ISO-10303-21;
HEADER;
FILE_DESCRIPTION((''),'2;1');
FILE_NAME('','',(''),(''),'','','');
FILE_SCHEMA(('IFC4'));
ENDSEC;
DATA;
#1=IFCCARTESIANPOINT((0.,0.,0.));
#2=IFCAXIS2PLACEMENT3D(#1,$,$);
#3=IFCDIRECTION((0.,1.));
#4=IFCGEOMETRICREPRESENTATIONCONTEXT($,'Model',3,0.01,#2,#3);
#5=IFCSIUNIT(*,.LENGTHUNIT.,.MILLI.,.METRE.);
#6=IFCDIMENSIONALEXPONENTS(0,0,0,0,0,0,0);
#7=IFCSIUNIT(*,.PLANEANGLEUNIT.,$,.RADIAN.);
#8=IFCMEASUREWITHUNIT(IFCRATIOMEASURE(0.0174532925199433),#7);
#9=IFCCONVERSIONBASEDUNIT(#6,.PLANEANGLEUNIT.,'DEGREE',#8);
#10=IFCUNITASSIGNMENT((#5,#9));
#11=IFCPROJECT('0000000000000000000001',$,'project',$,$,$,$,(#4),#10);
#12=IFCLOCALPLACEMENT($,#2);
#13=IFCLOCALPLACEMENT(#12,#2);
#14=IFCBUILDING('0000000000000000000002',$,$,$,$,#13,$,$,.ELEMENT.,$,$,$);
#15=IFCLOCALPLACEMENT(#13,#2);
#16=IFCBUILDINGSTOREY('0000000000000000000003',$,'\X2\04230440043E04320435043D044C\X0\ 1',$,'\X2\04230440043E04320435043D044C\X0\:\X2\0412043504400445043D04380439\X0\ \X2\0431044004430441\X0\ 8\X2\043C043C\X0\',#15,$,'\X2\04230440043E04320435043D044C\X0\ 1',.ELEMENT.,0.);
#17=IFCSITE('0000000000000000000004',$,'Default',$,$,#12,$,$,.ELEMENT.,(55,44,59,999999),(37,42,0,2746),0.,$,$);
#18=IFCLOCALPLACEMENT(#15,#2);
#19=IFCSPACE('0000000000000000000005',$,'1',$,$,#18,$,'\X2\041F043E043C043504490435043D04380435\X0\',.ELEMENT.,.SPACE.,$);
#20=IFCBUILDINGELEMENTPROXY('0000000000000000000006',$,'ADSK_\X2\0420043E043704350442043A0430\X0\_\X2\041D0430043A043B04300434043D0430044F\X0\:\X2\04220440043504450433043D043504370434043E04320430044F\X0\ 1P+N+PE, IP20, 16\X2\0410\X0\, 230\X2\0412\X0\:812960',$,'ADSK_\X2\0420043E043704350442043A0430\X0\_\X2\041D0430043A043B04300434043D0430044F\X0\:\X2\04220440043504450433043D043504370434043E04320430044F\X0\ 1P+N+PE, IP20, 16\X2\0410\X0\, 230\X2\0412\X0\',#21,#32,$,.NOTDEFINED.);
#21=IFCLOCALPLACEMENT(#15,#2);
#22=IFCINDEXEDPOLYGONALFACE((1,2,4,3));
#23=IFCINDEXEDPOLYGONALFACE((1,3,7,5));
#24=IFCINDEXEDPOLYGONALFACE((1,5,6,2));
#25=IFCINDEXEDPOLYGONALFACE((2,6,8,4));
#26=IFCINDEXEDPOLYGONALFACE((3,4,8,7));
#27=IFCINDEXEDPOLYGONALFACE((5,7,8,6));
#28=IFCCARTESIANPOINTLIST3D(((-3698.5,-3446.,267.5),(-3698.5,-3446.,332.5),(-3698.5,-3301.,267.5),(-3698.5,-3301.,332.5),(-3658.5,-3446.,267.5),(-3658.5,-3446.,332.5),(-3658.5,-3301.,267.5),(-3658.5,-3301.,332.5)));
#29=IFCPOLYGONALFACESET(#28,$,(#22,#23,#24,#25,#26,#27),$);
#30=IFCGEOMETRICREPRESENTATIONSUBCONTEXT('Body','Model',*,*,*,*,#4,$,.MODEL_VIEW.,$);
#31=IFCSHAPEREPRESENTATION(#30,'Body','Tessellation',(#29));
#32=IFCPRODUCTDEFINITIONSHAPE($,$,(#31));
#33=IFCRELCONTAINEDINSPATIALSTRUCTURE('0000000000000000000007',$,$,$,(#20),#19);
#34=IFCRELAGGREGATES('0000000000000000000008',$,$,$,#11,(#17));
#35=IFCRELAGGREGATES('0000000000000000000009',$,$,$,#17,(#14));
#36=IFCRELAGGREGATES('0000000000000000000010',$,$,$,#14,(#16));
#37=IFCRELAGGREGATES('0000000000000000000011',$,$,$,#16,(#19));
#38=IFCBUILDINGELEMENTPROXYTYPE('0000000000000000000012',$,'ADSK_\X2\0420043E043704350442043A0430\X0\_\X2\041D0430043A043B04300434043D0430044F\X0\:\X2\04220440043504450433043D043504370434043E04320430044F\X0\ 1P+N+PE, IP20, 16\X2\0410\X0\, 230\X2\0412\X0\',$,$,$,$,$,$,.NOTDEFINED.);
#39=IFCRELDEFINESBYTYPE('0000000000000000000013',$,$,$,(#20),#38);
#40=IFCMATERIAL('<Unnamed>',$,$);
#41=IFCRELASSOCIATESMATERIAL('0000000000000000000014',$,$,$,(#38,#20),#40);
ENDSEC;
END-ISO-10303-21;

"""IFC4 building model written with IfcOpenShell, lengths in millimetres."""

from ifc_helpers import new_model, entity, si_unit, converted_unit, direction, frame, origin, origin_2d_with_axis, place, context, subcontext, project, spatial, rectangle, extrude, source, transform, mapped, material, type_object, type_shapes, element, save


model = new_model("IFC4")

# Units and contexts
model_context = context("Model", 3, precision=0.01, world=origin(), true_north=direction((0.0, 1.0)))
body_context = subcontext(model_context, "Body", "Model", "MODEL_VIEW")
ifc_project = project(units=[si_unit("LENGTHUNIT", "METRE", prefix="MILLI"), converted_unit("PLANEANGLEUNIT", "DEGREE", entity("IfcRatioMeasure", 0.0174532925199433), si_unit("PLANEANGLEUNIT", "RADIAN"), dimensions=[0, 0, 0, 0, 0, 0, 0])], contexts=[model_context])

# Site, building, storey
site_placement = place(None, origin())
site = spatial("IfcSite", under=ifc_project, at=site_placement, Name="Default", CompositionType="ELEMENT", RefLatitude=(55, 44, 59, 999999), RefLongitude=(37, 42, 0, 2746), RefElevation=0.0)
building_placement = place(site_placement, origin())
building = spatial("IfcBuilding", under=site, at=building_placement, CompositionType="ELEMENT")
storey_placement = place(building_placement, origin())
storey = spatial("IfcBuildingStorey", under=building, at=storey_placement, Name="Уровень 1", ObjectType="Уровень:Верхний брус 8мм", LongName="Уровень 1", CompositionType="ELEMENT", Elevation=0.0)

# Shared definitions
space_placement = place(storey_placement, origin())
space = spatial("IfcSpace", under=storey, at=space_placement, Name="1", LongName="Помещение", CompositionType="ELEMENT", PredefinedType="SPACE")

# Building element proxy
ifc_material_1 = material(Name="<Unnamed>")
building_element_proxy_type = type_object("IfcBuildingElementProxyType", Name="ADSK_Розетка_Накладная:Трехгнездовая 1P+N+PE, IP20, 16А, 230В", PredefinedType="NOTDEFINED", material=ifc_material_1)
shared_shape = source(origin(), body_context, "Body", "SweptSolid", [
    extrude(rectangle(XDim=145.0, YDim=40.0, at=origin_2d_with_axis()), frame((0.0, 20.0, -32.5), z_axis=(0.0, 0.0, 1.0), x_axis=(-1.0, 0.0, 0.0)), (0.0, 0.0, 1.0), 65.0),
])
type_shapes(building_element_proxy_type, [shared_shape])
proxy_placement = place(space_placement, frame((-3698.5, -3373.5, 300.0), z_axis=(0.0, 0.0, 1.0), x_axis=(0.0, -1.0, 0.0)))
element("IfcBuildingElementProxy", 1, at=proxy_placement, inside=space, type_object=building_element_proxy_type, material=ifc_material_1, Name="ADSK_Розетка_Накладная:Трехгнездовая 1P+N+PE, IP20, 16А, 230В:812960", ObjectType="ADSK_Розетка_Накладная:Трехгнездовая 1P+N+PE, IP20, 16А, 230В", PredefinedType="NOTDEFINED", context=body_context, shape_type="MappedRepresentation", body=[
    mapped(shared_shape, transform((0.0, 0.0, 0.0), scale=1.0)),
])

save(model, "model.ifc")
